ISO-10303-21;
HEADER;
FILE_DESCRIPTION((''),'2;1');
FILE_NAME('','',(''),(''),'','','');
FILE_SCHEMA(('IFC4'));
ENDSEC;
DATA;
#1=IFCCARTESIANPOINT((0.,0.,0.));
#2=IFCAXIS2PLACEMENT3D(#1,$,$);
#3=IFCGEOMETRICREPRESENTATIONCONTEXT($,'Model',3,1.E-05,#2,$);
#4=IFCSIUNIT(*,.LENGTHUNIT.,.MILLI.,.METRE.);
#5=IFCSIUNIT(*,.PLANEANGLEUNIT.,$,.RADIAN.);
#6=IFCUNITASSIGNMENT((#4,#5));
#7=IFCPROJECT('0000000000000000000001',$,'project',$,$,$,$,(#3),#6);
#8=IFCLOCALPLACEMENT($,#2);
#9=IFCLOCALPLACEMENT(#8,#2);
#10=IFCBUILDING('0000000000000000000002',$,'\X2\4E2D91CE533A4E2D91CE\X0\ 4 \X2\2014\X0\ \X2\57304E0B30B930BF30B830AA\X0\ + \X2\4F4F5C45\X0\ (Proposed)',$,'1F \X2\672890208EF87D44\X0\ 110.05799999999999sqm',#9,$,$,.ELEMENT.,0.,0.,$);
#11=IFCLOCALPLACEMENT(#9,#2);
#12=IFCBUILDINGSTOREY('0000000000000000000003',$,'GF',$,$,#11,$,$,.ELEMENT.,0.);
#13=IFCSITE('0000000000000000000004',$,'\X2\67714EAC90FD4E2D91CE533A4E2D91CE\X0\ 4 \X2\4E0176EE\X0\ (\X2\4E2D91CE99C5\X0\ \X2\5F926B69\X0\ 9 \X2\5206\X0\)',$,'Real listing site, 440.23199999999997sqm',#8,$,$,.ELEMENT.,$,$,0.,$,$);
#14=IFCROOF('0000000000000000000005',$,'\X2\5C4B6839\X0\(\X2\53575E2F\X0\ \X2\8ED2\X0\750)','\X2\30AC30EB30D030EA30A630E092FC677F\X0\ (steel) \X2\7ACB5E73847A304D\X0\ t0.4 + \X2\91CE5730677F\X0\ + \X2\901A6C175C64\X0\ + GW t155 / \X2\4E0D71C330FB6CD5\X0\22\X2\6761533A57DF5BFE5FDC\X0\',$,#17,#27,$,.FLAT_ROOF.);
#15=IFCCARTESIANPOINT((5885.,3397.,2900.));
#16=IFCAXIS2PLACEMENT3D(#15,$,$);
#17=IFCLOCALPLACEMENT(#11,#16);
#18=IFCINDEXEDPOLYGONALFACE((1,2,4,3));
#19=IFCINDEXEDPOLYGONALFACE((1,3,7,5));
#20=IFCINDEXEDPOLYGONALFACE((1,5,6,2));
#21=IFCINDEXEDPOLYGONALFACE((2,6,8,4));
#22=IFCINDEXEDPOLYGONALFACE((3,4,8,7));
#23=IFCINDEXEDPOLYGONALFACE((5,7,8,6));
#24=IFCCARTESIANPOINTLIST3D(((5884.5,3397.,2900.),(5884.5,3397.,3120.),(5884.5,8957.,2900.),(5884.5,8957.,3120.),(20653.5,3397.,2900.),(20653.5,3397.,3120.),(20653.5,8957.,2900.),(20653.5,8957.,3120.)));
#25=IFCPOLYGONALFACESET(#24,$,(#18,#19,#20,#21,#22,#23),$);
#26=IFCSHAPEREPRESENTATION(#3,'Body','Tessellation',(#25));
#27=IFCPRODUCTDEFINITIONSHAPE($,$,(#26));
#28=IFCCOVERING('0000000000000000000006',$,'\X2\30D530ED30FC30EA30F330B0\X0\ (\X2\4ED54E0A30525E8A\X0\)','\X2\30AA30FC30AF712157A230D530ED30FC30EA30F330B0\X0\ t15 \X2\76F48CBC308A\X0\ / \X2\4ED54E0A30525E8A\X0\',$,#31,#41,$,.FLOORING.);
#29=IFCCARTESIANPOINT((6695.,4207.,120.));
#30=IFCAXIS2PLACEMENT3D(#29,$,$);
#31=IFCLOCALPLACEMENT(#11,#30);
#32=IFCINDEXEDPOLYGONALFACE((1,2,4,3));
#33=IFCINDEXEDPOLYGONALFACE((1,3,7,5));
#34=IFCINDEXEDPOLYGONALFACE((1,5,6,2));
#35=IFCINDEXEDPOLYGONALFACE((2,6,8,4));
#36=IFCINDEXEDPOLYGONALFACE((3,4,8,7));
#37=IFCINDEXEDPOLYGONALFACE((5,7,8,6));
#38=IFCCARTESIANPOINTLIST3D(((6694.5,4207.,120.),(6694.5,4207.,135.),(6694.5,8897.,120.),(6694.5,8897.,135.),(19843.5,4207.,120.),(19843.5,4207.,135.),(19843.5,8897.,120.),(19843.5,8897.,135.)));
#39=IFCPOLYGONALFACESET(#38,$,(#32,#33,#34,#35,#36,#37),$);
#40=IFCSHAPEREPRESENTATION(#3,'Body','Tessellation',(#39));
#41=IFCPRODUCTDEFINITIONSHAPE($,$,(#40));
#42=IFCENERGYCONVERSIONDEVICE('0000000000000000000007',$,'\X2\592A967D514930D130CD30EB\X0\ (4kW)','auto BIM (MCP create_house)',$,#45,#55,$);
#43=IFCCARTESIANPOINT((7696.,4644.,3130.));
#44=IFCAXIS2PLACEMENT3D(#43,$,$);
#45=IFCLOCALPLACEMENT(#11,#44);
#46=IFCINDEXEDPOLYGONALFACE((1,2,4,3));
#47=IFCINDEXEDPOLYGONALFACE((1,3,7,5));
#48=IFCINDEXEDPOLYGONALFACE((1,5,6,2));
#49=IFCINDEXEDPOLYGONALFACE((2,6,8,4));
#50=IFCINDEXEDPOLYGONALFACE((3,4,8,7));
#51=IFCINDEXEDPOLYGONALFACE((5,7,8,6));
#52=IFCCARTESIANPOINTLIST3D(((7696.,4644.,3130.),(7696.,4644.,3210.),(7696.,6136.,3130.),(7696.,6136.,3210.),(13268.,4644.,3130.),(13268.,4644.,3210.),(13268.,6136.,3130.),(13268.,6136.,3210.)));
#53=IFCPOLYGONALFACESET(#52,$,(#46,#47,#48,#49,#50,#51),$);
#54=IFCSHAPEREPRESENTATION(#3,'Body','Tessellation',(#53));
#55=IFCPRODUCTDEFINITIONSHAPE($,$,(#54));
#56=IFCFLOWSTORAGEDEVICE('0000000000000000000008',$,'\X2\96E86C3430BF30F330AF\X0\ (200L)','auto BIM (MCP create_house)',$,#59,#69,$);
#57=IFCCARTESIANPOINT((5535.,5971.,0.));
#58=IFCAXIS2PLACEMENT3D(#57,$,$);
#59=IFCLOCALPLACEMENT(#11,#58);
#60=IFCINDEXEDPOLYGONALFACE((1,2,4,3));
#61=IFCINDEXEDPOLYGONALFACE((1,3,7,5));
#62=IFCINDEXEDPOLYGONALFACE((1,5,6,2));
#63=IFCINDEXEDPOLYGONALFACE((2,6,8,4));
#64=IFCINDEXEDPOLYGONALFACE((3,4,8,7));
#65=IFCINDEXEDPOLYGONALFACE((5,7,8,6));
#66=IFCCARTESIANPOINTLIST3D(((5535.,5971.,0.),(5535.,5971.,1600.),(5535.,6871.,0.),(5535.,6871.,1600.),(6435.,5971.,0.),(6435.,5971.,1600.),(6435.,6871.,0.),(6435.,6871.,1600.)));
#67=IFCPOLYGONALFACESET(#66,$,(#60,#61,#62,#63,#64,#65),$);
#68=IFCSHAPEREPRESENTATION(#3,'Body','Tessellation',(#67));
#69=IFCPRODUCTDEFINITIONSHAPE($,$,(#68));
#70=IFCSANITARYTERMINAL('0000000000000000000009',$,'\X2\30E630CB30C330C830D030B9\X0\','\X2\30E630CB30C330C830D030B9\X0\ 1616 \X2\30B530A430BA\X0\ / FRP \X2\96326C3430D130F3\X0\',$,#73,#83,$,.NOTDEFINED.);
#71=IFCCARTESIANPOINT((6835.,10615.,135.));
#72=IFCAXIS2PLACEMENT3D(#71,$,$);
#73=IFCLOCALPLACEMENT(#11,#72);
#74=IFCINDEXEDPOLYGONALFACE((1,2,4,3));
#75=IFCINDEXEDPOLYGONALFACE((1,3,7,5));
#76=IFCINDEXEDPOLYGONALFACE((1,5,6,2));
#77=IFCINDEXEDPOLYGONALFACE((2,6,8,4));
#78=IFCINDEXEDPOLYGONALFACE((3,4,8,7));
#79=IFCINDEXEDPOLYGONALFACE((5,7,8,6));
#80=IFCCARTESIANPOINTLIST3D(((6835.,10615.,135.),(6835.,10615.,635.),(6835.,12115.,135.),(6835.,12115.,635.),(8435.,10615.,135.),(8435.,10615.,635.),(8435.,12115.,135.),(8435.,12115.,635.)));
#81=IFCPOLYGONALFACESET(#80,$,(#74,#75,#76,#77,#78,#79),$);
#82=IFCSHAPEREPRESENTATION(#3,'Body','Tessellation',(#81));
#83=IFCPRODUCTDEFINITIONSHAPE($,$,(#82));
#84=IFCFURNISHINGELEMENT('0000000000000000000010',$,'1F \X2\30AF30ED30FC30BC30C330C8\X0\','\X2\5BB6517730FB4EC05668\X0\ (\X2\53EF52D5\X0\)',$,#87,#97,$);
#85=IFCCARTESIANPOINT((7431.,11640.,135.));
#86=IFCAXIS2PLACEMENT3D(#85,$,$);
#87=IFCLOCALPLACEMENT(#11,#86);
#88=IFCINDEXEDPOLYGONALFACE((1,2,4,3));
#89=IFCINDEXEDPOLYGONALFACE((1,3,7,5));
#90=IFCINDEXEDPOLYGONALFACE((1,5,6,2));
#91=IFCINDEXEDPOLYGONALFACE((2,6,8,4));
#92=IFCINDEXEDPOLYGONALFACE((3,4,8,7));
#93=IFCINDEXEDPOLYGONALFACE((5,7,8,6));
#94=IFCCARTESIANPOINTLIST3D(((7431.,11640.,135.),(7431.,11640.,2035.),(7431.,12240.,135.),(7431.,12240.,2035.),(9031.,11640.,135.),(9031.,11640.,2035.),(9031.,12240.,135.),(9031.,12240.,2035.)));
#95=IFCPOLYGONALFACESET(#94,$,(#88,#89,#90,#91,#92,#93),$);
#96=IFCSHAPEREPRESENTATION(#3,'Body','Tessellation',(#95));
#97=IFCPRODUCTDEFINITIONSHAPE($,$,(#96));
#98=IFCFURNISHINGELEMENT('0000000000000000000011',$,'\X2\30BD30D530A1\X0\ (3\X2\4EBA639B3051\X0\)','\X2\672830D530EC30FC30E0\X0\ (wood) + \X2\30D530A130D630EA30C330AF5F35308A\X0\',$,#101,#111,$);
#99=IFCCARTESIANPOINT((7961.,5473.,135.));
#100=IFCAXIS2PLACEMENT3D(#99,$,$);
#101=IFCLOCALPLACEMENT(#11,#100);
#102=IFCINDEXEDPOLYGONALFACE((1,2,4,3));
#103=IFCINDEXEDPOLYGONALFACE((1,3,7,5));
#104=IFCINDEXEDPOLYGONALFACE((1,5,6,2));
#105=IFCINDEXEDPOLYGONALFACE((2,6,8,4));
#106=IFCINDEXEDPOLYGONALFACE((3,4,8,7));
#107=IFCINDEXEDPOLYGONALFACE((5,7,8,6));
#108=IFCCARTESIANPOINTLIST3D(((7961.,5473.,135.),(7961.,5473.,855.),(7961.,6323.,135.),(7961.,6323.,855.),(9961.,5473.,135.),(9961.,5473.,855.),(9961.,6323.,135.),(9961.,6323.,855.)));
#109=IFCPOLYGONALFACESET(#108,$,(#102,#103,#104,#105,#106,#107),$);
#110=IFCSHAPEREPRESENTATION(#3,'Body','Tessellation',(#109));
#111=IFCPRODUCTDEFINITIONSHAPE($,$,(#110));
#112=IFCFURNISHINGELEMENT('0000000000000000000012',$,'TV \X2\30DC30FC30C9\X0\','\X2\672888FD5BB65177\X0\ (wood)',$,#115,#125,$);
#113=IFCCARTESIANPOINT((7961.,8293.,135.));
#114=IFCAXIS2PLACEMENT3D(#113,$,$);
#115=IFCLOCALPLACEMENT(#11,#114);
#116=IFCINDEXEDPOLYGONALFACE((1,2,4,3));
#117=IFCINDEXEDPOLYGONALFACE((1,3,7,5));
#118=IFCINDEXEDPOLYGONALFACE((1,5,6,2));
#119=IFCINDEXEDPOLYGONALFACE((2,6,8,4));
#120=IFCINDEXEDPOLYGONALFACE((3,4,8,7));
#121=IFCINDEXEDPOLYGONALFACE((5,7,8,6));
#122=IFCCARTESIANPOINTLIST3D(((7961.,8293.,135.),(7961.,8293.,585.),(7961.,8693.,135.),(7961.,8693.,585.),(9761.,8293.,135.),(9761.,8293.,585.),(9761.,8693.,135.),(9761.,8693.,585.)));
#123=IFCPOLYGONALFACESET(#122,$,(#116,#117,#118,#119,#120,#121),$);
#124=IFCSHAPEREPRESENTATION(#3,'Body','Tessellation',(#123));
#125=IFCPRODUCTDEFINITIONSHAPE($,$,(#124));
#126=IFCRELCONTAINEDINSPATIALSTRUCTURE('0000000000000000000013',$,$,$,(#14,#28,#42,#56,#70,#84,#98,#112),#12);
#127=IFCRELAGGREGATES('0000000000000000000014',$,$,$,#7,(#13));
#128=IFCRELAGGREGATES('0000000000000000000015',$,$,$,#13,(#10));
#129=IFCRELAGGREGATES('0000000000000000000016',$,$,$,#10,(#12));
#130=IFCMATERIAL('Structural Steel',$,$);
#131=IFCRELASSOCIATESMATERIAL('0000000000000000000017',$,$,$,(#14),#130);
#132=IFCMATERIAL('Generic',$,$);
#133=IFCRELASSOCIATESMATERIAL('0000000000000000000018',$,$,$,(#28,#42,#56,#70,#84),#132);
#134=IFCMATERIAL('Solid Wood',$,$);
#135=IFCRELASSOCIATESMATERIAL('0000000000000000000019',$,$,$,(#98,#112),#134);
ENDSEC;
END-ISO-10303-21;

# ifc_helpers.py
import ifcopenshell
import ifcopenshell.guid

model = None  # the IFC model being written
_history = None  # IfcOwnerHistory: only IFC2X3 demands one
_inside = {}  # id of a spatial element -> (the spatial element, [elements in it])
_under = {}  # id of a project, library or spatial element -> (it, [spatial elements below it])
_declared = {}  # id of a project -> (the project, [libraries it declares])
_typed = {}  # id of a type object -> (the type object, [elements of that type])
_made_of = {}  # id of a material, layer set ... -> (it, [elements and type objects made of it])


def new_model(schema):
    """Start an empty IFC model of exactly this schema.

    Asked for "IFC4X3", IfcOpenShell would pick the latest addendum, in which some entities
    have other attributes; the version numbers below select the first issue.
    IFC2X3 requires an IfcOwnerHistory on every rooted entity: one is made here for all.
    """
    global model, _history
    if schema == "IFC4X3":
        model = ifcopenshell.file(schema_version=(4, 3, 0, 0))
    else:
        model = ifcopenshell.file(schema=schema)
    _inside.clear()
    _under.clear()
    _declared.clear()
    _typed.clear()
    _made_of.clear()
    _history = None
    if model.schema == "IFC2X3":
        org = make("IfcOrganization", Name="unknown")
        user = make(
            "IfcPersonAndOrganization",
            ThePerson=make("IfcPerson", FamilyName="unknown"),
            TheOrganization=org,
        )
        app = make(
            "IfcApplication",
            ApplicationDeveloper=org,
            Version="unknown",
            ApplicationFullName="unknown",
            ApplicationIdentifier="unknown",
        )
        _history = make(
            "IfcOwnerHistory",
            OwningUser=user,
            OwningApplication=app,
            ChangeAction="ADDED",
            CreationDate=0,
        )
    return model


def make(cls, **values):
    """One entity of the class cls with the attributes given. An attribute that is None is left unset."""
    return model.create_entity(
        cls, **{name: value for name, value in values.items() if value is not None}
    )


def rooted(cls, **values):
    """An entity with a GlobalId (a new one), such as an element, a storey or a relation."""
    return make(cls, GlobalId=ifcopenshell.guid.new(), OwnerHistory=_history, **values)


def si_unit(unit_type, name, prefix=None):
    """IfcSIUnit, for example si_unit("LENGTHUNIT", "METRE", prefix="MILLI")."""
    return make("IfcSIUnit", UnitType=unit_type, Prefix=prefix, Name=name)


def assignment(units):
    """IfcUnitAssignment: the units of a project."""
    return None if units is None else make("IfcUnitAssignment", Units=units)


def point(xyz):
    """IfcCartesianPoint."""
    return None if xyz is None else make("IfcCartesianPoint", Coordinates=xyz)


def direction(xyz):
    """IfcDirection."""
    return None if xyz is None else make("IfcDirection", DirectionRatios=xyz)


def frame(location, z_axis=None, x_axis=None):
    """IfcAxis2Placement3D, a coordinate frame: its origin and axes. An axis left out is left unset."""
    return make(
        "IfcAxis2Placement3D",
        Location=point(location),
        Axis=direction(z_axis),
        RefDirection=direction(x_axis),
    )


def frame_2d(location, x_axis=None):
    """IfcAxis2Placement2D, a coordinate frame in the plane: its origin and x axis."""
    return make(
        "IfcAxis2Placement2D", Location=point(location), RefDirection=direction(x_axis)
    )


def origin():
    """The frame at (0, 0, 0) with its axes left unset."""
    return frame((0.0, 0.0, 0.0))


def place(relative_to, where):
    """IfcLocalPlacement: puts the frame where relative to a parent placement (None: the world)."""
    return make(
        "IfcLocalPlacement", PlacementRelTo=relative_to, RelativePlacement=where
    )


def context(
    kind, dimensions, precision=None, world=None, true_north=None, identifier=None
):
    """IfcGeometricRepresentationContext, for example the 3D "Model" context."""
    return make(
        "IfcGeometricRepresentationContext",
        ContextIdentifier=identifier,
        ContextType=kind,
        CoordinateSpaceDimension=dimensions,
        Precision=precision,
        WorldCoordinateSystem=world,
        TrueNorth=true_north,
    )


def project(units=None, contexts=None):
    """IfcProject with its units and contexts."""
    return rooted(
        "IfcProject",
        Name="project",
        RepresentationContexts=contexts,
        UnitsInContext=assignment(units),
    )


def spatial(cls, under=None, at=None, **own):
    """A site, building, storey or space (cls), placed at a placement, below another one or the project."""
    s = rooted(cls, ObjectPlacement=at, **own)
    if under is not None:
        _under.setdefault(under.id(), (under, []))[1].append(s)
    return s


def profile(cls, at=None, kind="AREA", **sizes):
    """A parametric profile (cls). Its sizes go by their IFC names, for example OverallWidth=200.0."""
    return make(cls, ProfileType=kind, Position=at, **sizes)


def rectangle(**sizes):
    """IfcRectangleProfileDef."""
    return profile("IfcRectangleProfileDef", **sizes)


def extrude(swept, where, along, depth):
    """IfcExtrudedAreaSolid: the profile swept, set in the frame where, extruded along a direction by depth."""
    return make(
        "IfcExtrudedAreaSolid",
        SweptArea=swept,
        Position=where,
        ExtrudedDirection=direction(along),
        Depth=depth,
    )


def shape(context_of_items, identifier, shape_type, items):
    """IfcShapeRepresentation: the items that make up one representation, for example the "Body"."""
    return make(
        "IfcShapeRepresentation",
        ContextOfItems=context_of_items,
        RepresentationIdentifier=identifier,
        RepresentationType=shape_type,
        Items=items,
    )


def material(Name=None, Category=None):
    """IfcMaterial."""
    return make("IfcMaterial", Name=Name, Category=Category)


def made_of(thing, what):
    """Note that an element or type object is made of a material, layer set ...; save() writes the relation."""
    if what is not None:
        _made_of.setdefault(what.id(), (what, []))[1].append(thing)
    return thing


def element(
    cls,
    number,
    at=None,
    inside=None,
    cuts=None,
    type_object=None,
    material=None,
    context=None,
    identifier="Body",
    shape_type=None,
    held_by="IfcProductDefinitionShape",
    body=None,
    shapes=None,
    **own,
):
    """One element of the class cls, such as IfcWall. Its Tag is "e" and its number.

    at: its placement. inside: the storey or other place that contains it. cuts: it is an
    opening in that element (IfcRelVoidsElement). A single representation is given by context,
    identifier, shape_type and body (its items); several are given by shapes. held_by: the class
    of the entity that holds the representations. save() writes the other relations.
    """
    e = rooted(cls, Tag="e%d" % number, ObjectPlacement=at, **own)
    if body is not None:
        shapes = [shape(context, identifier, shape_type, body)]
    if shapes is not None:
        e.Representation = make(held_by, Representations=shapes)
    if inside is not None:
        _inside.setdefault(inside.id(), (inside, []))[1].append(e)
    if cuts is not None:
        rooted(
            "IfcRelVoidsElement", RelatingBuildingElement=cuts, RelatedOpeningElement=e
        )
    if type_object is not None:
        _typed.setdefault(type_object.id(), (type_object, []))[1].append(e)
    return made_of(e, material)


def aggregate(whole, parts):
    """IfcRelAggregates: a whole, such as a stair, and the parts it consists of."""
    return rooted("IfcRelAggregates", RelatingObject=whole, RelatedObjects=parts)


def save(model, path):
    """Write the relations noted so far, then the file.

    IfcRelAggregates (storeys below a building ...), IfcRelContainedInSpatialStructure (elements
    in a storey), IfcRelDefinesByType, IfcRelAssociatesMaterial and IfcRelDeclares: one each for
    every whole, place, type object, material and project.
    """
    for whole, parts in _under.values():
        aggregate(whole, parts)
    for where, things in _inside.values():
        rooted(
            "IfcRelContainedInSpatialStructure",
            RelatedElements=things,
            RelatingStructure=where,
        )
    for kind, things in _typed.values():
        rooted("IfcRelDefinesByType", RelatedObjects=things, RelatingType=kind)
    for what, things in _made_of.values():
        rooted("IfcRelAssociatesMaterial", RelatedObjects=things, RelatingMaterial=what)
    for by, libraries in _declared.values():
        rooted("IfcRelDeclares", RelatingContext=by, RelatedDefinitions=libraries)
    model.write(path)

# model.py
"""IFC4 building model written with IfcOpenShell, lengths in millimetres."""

from ifc_helpers import new_model, si_unit, frame, frame_2d, origin, place, context, project, spatial, rectangle, extrude, material, element, save


model = new_model("IFC4")

# Units and contexts
model_context = context("Model", 3, precision=1e-05, world=origin())
ifc_project = project(units=[si_unit("LENGTHUNIT", "METRE", prefix="MILLI"), si_unit("PLANEANGLEUNIT", "RADIAN")], contexts=[model_context])

# Site, building, storey
site_placement = place(None, origin())
site = spatial("IfcSite", under=ifc_project, at=site_placement, Name="東京都中野区中野 4 丁目 (中野駅 徒歩 9 分)", ObjectType="Real listing site, 440.23199999999997sqm", CompositionType="ELEMENT", RefElevation=0.0)
building_placement = place(site_placement, origin())
building = spatial("IfcBuilding", under=site, at=building_placement, Name="中野区中野 4 — 地下スタジオ + 住居 (Proposed)", ObjectType="1F 木造軸組 110.05799999999999sqm", CompositionType="ELEMENT", ElevationOfRefHeight=0.0, ElevationOfTerrain=0.0)
storey_placement = place(building_placement, origin())
storey = spatial("IfcBuildingStorey", under=building, at=storey_placement, Name="GF", CompositionType="ELEMENT", Elevation=0.0)

# Shared definitions
ifc_material_1 = material(Name="Solid Wood")

# Roof
ifc_material_2 = material(Name="Structural Steel")
roof_1_placement = place(storey_placement, frame((5885.0, 3397.0, 2900.0)))
element("IfcRoof", 1, at=roof_1_placement, inside=storey, material=ifc_material_2, Name="屋根(南帯 軒750)", Description="ガルバリウム鋼板 (steel) 立平葺き t0.4 + 野地板 + 通気層 + GW t155 / 不燃・法22条区域対応", PredefinedType="FLAT_ROOF", context=model_context, shape_type="SweptSolid", body=[
    extrude(rectangle(XDim=14769.0, YDim=5560.0, at=frame_2d((7384.0, 2780.0))), frame((5885.0, 3397.0, 2900.0)), (0.0, 0.0, 1.0), 220.0),
])

# Covering
ifc_material_3 = material(Name="Generic")
covering_1_placement = place(storey_placement, frame((6695.0, 4207.0, 120.0)))
element("IfcCovering", 2, at=covering_1_placement, inside=storey, material=ifc_material_3, Name="フローリング (仕上げ床)", Description="オーク無垢フローリング t15 直貼り / 仕上げ床", PredefinedType="FLOORING", context=model_context, shape_type="SweptSolid", body=[
    extrude(rectangle(XDim=13149.0, YDim=4690.0, at=frame_2d((6574.0, 2345.0))), frame((6695.0, 4207.0, 120.0)), (0.0, 0.0, 1.0), 15.0),
])

# Energy conversion device
energy_conversion_device_placement = place(storey_placement, frame((7696.0, 4644.0, 3130.0)))
element("IfcEnergyConversionDevice", 3, at=energy_conversion_device_placement, inside=storey, material=ifc_material_3, Name="太陽光パネル (4kW)", Description="auto BIM (MCP create_house)", context=model_context, shape_type="SweptSolid", body=[
    extrude(rectangle(XDim=5572.0, YDim=1492.0, at=frame_2d((2786.0, 746.0))), frame((7696.0, 4644.0, 3130.0)), (0.0, 0.0, 1.0), 80.0),
])

# Flow storage device
flow_storage_device_placement = place(storey_placement, frame((5535.0, 5971.0, 0.0)))
element("IfcFlowStorageDevice", 4, at=flow_storage_device_placement, inside=storey, material=ifc_material_3, Name="雨水タンク (200L)", Description="auto BIM (MCP create_house)", context=model_context, shape_type="SweptSolid", body=[
    extrude(rectangle(XDim=900.0, YDim=900.0, at=frame_2d((450.0, 450.0))), frame((5535.0, 5971.0, 0.0)), (0.0, 0.0, 1.0), 1600.0),
])

# Sanitary terminal
sanitary_terminal_placement = place(storey_placement, frame((6835.0, 10615.0, 135.0)))
element("IfcSanitaryTerminal", 5, at=sanitary_terminal_placement, inside=storey, material=ifc_material_3, Name="ユニットバス", Description="ユニットバス 1616 サイズ / FRP 防水パン", PredefinedType="NOTDEFINED", context=model_context, shape_type="SweptSolid", body=[
    extrude(rectangle(XDim=1600.0, YDim=1500.0, at=frame_2d((800.0, 750.0))), frame((6835.0, 10615.0, 135.0)), (0.0, 0.0, 1.0), 500.0),
])

# Furnishing elements
furnishing_1_placement = place(storey_placement, frame((7431.0, 11640.0, 135.0)))
element("IfcFurnishingElement", 6, at=furnishing_1_placement, inside=storey, material=ifc_material_3, Name="1F クローゼット", Description="家具・什器 (可動)", context=model_context, shape_type="SweptSolid", body=[
    extrude(rectangle(XDim=1600.0, YDim=600.0, at=frame_2d((800.0, 300.0))), frame((7431.0, 11640.0, 135.0)), (0.0, 0.0, 1.0), 1900.0),
])
furnishing_2_placement = place(storey_placement, frame((7961.0, 5473.0, 135.0)))
element("IfcFurnishingElement", 7, at=furnishing_2_placement, inside=storey, material=ifc_material_1, Name="ソファ (3人掛け)", Description="木フレーム (wood) + ファブリック張り", context=model_context, shape_type="SweptSolid", body=[
    extrude(rectangle(XDim=2000.0, YDim=850.0, at=frame_2d((1000.0, 425.0))), frame((7961.0, 5473.0, 135.0)), (0.0, 0.0, 1.0), 720.0),
])
furnishing_3_placement = place(storey_placement, frame((7961.0, 8293.0, 135.0)))
element("IfcFurnishingElement", 8, at=furnishing_3_placement, inside=storey, material=ifc_material_1, Name="TV ボード", Description="木製家具 (wood)", context=model_context, shape_type="SweptSolid", body=[
    extrude(rectangle(XDim=1800.0, YDim=400.0, at=frame_2d((900.0, 200.0))), frame((7961.0, 8293.0, 135.0)), (0.0, 0.0, 1.0), 450.0),
])

save(model, "model.ifc")
